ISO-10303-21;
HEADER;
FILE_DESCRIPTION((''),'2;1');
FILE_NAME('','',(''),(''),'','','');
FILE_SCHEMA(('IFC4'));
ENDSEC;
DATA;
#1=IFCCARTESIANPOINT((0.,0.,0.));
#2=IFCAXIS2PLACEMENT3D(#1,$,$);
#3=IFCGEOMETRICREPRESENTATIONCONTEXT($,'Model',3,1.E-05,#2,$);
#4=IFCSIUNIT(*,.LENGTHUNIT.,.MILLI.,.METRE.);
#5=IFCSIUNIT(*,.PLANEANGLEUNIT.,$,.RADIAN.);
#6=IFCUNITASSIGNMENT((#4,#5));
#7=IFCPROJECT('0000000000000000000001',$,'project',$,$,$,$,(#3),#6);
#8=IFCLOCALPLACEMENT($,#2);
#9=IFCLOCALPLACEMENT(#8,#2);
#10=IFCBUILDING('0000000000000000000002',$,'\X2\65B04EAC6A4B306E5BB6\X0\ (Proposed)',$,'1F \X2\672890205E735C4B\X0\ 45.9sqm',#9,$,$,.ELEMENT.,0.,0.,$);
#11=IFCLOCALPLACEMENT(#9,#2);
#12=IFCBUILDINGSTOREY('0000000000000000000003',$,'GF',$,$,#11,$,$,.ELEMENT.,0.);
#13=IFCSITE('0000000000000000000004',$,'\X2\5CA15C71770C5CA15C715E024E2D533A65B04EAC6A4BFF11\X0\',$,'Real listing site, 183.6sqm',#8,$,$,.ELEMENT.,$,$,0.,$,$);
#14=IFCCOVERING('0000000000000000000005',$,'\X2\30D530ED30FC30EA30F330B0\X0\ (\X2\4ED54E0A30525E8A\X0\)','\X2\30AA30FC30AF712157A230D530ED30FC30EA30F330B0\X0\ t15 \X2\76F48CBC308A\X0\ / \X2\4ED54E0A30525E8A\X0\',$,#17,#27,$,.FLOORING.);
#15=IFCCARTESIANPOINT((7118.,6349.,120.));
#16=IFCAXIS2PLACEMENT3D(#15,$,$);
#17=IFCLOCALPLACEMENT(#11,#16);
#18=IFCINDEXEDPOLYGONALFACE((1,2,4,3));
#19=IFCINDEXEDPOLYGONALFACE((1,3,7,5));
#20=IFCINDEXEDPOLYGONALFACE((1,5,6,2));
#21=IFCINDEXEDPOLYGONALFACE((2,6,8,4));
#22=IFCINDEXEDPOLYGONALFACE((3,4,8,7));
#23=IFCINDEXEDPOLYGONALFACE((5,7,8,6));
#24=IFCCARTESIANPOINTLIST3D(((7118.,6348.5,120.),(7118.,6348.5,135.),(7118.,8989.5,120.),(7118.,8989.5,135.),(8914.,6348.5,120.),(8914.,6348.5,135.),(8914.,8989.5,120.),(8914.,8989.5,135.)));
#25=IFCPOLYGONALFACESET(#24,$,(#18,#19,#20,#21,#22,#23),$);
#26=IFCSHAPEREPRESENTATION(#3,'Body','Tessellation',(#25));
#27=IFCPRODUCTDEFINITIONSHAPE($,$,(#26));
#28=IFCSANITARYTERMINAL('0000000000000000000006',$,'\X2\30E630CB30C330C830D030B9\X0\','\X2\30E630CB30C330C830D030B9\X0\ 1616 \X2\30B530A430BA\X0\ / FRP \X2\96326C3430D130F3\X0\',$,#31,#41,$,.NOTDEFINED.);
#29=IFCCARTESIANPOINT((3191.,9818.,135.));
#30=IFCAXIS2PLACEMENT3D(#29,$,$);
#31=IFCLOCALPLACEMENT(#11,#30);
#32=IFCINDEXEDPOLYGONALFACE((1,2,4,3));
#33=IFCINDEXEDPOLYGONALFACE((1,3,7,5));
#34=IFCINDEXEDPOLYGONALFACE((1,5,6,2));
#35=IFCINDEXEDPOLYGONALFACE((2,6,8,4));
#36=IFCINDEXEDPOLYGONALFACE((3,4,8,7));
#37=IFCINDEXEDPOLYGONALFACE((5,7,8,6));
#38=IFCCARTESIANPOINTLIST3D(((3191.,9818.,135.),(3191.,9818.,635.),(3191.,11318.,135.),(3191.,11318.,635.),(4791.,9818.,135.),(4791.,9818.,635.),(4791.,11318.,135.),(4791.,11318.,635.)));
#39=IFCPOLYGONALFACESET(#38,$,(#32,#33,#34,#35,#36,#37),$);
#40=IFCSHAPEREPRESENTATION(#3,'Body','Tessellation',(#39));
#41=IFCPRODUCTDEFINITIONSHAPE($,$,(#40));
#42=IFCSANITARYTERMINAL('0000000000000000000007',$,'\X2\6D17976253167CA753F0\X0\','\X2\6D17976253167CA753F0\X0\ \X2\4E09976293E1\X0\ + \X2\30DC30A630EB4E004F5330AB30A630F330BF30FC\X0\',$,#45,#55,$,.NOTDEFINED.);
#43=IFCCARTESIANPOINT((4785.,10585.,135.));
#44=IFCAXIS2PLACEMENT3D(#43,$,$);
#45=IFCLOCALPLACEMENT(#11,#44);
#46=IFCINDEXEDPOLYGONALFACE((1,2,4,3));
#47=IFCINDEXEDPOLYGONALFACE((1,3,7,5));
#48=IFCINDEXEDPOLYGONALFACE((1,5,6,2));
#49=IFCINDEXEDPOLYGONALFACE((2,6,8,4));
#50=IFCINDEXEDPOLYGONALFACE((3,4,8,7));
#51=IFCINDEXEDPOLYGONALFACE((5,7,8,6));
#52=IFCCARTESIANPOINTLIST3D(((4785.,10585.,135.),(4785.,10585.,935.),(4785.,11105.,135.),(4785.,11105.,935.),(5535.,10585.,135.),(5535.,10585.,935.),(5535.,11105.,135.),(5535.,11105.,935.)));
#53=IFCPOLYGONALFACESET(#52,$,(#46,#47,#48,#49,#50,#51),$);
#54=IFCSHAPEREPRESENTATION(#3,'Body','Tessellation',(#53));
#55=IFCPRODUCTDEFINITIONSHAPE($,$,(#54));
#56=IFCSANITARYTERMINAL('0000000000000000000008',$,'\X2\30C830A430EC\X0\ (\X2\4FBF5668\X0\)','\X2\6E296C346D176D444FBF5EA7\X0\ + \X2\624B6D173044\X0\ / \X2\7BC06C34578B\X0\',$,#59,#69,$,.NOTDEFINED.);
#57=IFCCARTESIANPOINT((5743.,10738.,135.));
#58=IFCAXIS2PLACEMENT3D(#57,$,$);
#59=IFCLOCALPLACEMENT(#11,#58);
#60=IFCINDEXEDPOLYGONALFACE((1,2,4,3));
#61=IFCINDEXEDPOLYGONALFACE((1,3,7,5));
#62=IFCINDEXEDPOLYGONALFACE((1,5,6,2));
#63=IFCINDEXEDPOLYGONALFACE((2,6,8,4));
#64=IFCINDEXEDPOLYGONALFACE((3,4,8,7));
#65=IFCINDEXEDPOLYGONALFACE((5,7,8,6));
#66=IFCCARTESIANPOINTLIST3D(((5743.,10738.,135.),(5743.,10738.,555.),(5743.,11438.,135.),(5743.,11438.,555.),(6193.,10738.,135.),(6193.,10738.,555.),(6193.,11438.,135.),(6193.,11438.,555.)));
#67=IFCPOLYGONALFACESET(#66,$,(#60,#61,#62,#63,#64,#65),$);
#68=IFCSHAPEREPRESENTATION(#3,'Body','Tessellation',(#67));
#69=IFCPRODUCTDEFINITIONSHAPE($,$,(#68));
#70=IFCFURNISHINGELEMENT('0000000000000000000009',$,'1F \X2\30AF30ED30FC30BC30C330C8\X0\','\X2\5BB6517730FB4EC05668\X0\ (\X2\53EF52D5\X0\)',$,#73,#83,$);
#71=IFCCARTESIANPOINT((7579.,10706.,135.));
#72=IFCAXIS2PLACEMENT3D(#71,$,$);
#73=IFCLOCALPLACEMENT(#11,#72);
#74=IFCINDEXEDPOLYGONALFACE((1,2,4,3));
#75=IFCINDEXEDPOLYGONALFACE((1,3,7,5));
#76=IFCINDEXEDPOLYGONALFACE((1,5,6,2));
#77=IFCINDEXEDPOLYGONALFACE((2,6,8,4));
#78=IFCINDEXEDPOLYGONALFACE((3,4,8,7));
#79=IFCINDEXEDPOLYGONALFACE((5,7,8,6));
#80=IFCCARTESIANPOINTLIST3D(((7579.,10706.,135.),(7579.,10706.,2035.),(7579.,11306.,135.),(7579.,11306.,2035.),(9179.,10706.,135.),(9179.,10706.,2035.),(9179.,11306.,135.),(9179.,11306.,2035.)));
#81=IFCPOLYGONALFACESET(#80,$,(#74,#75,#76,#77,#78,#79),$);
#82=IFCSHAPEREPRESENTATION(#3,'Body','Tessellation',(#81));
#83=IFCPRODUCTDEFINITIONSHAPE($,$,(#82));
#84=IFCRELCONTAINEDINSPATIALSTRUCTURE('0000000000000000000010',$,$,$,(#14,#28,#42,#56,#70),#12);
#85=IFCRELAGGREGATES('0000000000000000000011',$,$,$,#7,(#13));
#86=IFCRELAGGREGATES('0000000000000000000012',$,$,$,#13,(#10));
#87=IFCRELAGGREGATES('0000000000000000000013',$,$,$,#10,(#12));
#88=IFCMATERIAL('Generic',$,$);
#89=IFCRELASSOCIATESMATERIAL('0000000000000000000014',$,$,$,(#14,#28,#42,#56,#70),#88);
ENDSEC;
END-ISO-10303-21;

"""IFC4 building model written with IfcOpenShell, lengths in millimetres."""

from ifc_helpers import new_model, si_unit, frame, frame_2d, origin, place, context, project, spatial, rectangle, extrude, material, element, save


model = new_model("IFC4")

# Units and contexts
model_context = context("Model", 3, precision=1e-05, world=origin())
ifc_project = project(units=[si_unit("LENGTHUNIT", "METRE", prefix="MILLI"), si_unit("PLANEANGLEUNIT", "RADIAN")], contexts=[model_context])

# Site, building, storey
site_placement = place(None, origin())
site = spatial("IfcSite", under=ifc_project, at=site_placement, Name="岡山県岡山市中区新京橋１", ObjectType="Real listing site, 183.6sqm", CompositionType="ELEMENT", RefElevation=0.0)
building_placement = place(site_placement, origin())
building = spatial("IfcBuilding", under=site, at=building_placement, Name="新京橋の家 (Proposed)", ObjectType="1F 木造平屋 45.9sqm", CompositionType="ELEMENT", ElevationOfRefHeight=0.0, ElevationOfTerrain=0.0)
storey_placement = place(building_placement, origin())
storey = spatial("IfcBuildingStorey", under=building, at=storey_placement, Name="GF", CompositionType="ELEMENT", Elevation=0.0)

# Covering
ifc_material_1 = material(Name="Generic")
covering_1_placement = place(storey_placement, frame((7118.0, 6349.0, 120.0)))
element("IfcCovering", 1, at=covering_1_placement, inside=storey, material=ifc_material_1, Name="フローリング (仕上げ床)", Description="オーク無垢フローリング t15 直貼り / 仕上げ床", PredefinedType="FLOORING", context=model_context, shape_type="SweptSolid", body=[
    extrude(rectangle(XDim=1796.0, YDim=2641.0, at=frame_2d((898.0, 1320.0))), frame((7118.0, 6349.0, 120.0)), (0.0, 0.0, 1.0), 15.0),
])

# Sanitary terminals
sanitary_terminal_1_placement = place(storey_placement, frame((3191.0, 9818.0, 135.0)))
element("IfcSanitaryTerminal", 2, at=sanitary_terminal_1_placement, inside=storey, material=ifc_material_1, Name="ユニットバス", Description="ユニットバス 1616 サイズ / FRP 防水パン", PredefinedType="NOTDEFINED", context=model_context, shape_type="SweptSolid", body=[
    extrude(rectangle(XDim=1600.0, YDim=1500.0, at=frame_2d((800.0, 750.0))), frame((3191.0, 9818.0, 135.0)), (0.0, 0.0, 1.0), 500.0),
])
sanitary_terminal_2_placement = place(storey_placement, frame((4785.0, 10585.0, 135.0)))
element("IfcSanitaryTerminal", 3, at=sanitary_terminal_2_placement, inside=storey, material=ifc_material_1, Name="洗面化粧台", Description="洗面化粧台 三面鏡 + ボウル一体カウンター", PredefinedType="NOTDEFINED", context=model_context, shape_type="SweptSolid", body=[
    extrude(rectangle(XDim=750.0, YDim=520.0, at=frame_2d((375.0, 260.0))), frame((4785.0, 10585.0, 135.0)), (0.0, 0.0, 1.0), 800.0),
])
sanitary_terminal_3_placement = place(storey_placement, frame((5743.0, 10738.0, 135.0)))
element("IfcSanitaryTerminal", 4, at=sanitary_terminal_3_placement, inside=storey, material=ifc_material_1, Name="トイレ (便器)", Description="温水洗浄便座 + 手洗い / 節水型", PredefinedType="NOTDEFINED", context=model_context, shape_type="SweptSolid", body=[
    extrude(rectangle(XDim=450.0, YDim=700.0, at=frame_2d((225.0, 350.0))), frame((5743.0, 10738.0, 135.0)), (0.0, 0.0, 1.0), 420.0),
])

# Furnishing element
furnishing_placement = place(storey_placement, frame((7579.0, 10706.0, 135.0)))
element("IfcFurnishingElement", 5, at=furnishing_placement, inside=storey, material=ifc_material_1, Name="1F クローゼット", Description="家具・什器 (可動)", context=model_context, shape_type="SweptSolid", body=[
    extrude(rectangle(XDim=1600.0, YDim=600.0, at=frame_2d((800.0, 300.0))), frame((7579.0, 10706.0, 135.0)), (0.0, 0.0, 1.0), 1900.0),
])

save(model, "model.ifc")
